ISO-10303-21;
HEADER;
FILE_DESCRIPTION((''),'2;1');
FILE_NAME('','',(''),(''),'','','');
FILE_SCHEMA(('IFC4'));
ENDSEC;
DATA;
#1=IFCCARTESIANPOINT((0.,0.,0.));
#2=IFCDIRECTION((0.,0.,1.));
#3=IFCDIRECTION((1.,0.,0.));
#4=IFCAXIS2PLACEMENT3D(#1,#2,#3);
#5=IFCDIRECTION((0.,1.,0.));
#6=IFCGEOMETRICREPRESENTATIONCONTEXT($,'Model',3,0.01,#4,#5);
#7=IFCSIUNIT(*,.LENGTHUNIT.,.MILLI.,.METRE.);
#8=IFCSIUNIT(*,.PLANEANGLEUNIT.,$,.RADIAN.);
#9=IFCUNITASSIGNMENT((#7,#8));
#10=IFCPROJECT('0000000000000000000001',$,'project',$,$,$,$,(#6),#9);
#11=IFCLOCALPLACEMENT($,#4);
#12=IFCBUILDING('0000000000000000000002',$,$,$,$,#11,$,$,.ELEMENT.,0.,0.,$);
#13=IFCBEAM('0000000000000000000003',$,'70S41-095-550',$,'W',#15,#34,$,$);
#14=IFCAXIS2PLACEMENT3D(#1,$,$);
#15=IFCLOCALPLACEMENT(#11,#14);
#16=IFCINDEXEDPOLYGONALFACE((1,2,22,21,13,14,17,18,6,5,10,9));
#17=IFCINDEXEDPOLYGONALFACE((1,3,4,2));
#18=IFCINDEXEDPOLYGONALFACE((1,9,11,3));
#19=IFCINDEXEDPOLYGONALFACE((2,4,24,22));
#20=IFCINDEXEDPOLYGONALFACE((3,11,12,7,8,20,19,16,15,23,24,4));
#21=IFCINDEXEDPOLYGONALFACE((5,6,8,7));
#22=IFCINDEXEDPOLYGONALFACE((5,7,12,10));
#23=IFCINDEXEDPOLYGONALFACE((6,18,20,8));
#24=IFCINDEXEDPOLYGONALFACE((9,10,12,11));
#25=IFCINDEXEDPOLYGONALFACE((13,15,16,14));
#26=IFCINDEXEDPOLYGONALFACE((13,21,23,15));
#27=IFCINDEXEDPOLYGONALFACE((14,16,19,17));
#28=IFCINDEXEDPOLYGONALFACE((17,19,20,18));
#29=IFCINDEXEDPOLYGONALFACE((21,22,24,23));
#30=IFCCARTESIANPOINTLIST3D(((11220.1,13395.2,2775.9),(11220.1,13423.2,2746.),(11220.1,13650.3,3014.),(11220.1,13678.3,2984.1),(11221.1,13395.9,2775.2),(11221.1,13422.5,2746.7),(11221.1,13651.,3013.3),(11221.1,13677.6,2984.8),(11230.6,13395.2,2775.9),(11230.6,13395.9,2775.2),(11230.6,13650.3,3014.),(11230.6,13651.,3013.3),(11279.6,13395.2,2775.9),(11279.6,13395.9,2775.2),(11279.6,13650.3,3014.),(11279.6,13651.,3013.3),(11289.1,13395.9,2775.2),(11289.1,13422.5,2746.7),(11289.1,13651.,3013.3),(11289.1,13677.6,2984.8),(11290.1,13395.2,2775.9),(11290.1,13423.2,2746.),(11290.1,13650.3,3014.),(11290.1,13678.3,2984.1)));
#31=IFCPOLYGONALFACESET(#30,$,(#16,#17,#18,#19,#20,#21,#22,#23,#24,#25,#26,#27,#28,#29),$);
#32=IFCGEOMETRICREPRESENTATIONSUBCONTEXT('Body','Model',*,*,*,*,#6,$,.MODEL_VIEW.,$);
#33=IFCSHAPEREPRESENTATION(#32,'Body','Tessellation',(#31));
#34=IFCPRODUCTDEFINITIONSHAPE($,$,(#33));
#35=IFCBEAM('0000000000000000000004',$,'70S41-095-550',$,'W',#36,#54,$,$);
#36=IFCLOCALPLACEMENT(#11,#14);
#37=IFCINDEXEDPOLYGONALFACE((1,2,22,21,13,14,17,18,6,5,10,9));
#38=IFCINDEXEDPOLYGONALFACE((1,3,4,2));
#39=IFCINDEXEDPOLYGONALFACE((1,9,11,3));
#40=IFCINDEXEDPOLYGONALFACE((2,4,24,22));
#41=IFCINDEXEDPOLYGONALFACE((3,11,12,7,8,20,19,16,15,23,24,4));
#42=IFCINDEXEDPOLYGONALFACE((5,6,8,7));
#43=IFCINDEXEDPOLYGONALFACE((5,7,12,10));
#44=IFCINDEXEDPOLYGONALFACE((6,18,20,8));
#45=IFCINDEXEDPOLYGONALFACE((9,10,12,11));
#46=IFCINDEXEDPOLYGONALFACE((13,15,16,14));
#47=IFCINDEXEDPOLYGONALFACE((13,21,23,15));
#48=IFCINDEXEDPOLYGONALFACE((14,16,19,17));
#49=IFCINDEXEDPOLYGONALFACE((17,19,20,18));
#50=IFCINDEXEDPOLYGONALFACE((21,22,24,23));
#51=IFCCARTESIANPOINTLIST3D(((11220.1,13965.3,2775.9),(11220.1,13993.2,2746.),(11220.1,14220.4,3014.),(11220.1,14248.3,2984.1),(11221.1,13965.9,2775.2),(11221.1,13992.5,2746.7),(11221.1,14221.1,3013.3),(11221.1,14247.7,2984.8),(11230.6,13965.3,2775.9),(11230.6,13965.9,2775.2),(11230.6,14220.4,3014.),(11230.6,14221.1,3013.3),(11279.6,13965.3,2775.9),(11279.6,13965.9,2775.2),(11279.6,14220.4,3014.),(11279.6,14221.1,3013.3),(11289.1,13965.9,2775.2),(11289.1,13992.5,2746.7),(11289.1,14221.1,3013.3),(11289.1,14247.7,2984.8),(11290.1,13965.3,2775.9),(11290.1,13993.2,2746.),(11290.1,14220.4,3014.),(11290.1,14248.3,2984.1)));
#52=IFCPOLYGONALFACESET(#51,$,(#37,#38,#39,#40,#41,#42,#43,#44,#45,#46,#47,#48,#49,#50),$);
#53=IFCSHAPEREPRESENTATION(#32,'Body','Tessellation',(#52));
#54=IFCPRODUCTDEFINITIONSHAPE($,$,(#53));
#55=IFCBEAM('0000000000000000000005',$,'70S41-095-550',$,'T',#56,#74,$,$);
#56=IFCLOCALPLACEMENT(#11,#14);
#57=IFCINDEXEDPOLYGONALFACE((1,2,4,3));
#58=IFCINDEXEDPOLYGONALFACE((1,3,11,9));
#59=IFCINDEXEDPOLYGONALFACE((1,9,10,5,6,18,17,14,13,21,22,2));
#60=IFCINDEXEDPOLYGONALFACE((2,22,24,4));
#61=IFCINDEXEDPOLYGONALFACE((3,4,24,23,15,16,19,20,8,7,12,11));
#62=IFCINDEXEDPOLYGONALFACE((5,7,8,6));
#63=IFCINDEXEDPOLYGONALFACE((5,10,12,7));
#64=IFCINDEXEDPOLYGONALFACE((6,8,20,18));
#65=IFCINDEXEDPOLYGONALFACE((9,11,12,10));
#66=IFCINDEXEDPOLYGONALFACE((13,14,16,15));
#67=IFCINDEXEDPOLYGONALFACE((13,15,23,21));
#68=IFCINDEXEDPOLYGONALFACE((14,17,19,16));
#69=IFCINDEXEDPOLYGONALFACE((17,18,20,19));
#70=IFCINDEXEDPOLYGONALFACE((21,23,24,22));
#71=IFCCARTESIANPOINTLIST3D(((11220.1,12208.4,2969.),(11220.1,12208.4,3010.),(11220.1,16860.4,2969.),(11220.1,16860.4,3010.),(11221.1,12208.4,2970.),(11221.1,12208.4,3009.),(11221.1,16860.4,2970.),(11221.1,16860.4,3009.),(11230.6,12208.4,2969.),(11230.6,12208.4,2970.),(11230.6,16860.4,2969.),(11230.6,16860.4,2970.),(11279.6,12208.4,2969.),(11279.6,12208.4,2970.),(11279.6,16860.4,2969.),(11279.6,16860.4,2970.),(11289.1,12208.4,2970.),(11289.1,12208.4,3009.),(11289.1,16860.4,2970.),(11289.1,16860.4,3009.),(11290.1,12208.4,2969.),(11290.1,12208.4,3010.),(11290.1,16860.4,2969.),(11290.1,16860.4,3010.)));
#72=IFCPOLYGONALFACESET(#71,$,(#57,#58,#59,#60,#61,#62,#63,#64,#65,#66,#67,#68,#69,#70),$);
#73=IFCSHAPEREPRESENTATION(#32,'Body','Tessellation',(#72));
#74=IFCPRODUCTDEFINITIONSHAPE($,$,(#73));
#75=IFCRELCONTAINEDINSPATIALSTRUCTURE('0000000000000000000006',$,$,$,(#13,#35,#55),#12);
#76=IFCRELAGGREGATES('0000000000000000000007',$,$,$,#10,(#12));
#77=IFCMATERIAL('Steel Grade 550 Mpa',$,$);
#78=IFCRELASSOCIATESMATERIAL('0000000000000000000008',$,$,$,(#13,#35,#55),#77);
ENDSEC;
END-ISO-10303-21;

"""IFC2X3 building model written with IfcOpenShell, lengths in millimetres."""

from ifc_helpers import new_model, si_unit, direction, frame, origin, origin_with_axes, origin_2d_with_axis, place, context, subcontext, project, spatial, c_section, extrude, source, transform, mapped, material, element, save


model = new_model("IFC2X3")

# Units and contexts
model_context = context("Model", 3, precision=0.01, world=origin_with_axes(), true_north=direction((0.0, 1.0, 0.0)))
body_context = subcontext(model_context, "Body", "Model", "MODEL_VIEW")
ifc_project = project(units=[si_unit("LENGTHUNIT", "METRE", prefix="MILLI"), si_unit("PLANEANGLEUNIT", "RADIAN")], contexts=[model_context])

# Building
building_placement = place(None, origin_with_axes())
building = spatial("IfcBuilding", under=ifc_project, at=building_placement, CompositionType="ELEMENT", ElevationOfRefHeight=0.0, ElevationOfTerrain=0.0)

# Shared definitions
ifc_material = material(Name="Steel Grade 550 Mpa")

# Beams
shared_shape_1 = source(origin(), body_context, "Body", "SweptSolid", [
    extrude(c_section(Depth=70.0, Width=41.0, WallThickness=1.0, Girth=10.5, at=origin_2d_with_axis()), origin_with_axes(), (0.0, 0.0, 1.0), 349.0),
])
beam_1_placement = place(None, frame((11255.1, 13664.3, 2999.1), z_axis=(0.0, -0.731064, -0.682308), x_axis=(0.0, -0.682308, 0.731064)))
element("IfcBeam", 1, at=beam_1_placement, inside=building, material=ifc_material, Name="70S41-095-550", ObjectType="W", context=body_context, shape_type="MappedRepresentation", body=[
    mapped(shared_shape_1, transform((0.0, 0.0, 0.0), scale=1.0)),
])
shared_shape_2 = source(origin(), body_context, "Body", "SweptSolid", [
    extrude(c_section(Depth=70.0, Width=41.0, WallThickness=1.0, Girth=10.5, at=origin_2d_with_axis()), origin_with_axes(), (0.0, 0.0, 1.0), 349.0),
])
beam_2_placement = place(None, frame((11255.1, 14234.4, 2999.1), z_axis=(0.0, -0.731064, -0.682308), x_axis=(0.0, -0.682308, 0.731064)))
element("IfcBeam", 2, at=beam_2_placement, inside=building, material=ifc_material, Name="70S41-095-550", ObjectType="W", context=body_context, shape_type="MappedRepresentation", body=[
    mapped(shared_shape_2, transform((0.0, 0.0, 0.0), scale=1.0)),
])
shared_shape_3 = source(origin(), body_context, "Body", "SweptSolid", [
    extrude(c_section(Depth=70.0, Width=41.0, WallThickness=1.0, Girth=10.5, at=origin_2d_with_axis()), origin_with_axes(), (0.0, 0.0, 1.0), 4652.0),
])
beam_3_placement = place(None, frame((11255.1, 12208.4, 2989.5), z_axis=(0.0, 1.0, 0.0), x_axis=(0.0, 0.0, -1.0)))
element("IfcBeam", 3, at=beam_3_placement, inside=building, material=ifc_material, Name="70S41-095-550", ObjectType="T", context=body_context, shape_type="MappedRepresentation", body=[
    mapped(shared_shape_3, transform((0.0, 0.0, 0.0), scale=1.0)),
])

save(model, "model.ifc")
